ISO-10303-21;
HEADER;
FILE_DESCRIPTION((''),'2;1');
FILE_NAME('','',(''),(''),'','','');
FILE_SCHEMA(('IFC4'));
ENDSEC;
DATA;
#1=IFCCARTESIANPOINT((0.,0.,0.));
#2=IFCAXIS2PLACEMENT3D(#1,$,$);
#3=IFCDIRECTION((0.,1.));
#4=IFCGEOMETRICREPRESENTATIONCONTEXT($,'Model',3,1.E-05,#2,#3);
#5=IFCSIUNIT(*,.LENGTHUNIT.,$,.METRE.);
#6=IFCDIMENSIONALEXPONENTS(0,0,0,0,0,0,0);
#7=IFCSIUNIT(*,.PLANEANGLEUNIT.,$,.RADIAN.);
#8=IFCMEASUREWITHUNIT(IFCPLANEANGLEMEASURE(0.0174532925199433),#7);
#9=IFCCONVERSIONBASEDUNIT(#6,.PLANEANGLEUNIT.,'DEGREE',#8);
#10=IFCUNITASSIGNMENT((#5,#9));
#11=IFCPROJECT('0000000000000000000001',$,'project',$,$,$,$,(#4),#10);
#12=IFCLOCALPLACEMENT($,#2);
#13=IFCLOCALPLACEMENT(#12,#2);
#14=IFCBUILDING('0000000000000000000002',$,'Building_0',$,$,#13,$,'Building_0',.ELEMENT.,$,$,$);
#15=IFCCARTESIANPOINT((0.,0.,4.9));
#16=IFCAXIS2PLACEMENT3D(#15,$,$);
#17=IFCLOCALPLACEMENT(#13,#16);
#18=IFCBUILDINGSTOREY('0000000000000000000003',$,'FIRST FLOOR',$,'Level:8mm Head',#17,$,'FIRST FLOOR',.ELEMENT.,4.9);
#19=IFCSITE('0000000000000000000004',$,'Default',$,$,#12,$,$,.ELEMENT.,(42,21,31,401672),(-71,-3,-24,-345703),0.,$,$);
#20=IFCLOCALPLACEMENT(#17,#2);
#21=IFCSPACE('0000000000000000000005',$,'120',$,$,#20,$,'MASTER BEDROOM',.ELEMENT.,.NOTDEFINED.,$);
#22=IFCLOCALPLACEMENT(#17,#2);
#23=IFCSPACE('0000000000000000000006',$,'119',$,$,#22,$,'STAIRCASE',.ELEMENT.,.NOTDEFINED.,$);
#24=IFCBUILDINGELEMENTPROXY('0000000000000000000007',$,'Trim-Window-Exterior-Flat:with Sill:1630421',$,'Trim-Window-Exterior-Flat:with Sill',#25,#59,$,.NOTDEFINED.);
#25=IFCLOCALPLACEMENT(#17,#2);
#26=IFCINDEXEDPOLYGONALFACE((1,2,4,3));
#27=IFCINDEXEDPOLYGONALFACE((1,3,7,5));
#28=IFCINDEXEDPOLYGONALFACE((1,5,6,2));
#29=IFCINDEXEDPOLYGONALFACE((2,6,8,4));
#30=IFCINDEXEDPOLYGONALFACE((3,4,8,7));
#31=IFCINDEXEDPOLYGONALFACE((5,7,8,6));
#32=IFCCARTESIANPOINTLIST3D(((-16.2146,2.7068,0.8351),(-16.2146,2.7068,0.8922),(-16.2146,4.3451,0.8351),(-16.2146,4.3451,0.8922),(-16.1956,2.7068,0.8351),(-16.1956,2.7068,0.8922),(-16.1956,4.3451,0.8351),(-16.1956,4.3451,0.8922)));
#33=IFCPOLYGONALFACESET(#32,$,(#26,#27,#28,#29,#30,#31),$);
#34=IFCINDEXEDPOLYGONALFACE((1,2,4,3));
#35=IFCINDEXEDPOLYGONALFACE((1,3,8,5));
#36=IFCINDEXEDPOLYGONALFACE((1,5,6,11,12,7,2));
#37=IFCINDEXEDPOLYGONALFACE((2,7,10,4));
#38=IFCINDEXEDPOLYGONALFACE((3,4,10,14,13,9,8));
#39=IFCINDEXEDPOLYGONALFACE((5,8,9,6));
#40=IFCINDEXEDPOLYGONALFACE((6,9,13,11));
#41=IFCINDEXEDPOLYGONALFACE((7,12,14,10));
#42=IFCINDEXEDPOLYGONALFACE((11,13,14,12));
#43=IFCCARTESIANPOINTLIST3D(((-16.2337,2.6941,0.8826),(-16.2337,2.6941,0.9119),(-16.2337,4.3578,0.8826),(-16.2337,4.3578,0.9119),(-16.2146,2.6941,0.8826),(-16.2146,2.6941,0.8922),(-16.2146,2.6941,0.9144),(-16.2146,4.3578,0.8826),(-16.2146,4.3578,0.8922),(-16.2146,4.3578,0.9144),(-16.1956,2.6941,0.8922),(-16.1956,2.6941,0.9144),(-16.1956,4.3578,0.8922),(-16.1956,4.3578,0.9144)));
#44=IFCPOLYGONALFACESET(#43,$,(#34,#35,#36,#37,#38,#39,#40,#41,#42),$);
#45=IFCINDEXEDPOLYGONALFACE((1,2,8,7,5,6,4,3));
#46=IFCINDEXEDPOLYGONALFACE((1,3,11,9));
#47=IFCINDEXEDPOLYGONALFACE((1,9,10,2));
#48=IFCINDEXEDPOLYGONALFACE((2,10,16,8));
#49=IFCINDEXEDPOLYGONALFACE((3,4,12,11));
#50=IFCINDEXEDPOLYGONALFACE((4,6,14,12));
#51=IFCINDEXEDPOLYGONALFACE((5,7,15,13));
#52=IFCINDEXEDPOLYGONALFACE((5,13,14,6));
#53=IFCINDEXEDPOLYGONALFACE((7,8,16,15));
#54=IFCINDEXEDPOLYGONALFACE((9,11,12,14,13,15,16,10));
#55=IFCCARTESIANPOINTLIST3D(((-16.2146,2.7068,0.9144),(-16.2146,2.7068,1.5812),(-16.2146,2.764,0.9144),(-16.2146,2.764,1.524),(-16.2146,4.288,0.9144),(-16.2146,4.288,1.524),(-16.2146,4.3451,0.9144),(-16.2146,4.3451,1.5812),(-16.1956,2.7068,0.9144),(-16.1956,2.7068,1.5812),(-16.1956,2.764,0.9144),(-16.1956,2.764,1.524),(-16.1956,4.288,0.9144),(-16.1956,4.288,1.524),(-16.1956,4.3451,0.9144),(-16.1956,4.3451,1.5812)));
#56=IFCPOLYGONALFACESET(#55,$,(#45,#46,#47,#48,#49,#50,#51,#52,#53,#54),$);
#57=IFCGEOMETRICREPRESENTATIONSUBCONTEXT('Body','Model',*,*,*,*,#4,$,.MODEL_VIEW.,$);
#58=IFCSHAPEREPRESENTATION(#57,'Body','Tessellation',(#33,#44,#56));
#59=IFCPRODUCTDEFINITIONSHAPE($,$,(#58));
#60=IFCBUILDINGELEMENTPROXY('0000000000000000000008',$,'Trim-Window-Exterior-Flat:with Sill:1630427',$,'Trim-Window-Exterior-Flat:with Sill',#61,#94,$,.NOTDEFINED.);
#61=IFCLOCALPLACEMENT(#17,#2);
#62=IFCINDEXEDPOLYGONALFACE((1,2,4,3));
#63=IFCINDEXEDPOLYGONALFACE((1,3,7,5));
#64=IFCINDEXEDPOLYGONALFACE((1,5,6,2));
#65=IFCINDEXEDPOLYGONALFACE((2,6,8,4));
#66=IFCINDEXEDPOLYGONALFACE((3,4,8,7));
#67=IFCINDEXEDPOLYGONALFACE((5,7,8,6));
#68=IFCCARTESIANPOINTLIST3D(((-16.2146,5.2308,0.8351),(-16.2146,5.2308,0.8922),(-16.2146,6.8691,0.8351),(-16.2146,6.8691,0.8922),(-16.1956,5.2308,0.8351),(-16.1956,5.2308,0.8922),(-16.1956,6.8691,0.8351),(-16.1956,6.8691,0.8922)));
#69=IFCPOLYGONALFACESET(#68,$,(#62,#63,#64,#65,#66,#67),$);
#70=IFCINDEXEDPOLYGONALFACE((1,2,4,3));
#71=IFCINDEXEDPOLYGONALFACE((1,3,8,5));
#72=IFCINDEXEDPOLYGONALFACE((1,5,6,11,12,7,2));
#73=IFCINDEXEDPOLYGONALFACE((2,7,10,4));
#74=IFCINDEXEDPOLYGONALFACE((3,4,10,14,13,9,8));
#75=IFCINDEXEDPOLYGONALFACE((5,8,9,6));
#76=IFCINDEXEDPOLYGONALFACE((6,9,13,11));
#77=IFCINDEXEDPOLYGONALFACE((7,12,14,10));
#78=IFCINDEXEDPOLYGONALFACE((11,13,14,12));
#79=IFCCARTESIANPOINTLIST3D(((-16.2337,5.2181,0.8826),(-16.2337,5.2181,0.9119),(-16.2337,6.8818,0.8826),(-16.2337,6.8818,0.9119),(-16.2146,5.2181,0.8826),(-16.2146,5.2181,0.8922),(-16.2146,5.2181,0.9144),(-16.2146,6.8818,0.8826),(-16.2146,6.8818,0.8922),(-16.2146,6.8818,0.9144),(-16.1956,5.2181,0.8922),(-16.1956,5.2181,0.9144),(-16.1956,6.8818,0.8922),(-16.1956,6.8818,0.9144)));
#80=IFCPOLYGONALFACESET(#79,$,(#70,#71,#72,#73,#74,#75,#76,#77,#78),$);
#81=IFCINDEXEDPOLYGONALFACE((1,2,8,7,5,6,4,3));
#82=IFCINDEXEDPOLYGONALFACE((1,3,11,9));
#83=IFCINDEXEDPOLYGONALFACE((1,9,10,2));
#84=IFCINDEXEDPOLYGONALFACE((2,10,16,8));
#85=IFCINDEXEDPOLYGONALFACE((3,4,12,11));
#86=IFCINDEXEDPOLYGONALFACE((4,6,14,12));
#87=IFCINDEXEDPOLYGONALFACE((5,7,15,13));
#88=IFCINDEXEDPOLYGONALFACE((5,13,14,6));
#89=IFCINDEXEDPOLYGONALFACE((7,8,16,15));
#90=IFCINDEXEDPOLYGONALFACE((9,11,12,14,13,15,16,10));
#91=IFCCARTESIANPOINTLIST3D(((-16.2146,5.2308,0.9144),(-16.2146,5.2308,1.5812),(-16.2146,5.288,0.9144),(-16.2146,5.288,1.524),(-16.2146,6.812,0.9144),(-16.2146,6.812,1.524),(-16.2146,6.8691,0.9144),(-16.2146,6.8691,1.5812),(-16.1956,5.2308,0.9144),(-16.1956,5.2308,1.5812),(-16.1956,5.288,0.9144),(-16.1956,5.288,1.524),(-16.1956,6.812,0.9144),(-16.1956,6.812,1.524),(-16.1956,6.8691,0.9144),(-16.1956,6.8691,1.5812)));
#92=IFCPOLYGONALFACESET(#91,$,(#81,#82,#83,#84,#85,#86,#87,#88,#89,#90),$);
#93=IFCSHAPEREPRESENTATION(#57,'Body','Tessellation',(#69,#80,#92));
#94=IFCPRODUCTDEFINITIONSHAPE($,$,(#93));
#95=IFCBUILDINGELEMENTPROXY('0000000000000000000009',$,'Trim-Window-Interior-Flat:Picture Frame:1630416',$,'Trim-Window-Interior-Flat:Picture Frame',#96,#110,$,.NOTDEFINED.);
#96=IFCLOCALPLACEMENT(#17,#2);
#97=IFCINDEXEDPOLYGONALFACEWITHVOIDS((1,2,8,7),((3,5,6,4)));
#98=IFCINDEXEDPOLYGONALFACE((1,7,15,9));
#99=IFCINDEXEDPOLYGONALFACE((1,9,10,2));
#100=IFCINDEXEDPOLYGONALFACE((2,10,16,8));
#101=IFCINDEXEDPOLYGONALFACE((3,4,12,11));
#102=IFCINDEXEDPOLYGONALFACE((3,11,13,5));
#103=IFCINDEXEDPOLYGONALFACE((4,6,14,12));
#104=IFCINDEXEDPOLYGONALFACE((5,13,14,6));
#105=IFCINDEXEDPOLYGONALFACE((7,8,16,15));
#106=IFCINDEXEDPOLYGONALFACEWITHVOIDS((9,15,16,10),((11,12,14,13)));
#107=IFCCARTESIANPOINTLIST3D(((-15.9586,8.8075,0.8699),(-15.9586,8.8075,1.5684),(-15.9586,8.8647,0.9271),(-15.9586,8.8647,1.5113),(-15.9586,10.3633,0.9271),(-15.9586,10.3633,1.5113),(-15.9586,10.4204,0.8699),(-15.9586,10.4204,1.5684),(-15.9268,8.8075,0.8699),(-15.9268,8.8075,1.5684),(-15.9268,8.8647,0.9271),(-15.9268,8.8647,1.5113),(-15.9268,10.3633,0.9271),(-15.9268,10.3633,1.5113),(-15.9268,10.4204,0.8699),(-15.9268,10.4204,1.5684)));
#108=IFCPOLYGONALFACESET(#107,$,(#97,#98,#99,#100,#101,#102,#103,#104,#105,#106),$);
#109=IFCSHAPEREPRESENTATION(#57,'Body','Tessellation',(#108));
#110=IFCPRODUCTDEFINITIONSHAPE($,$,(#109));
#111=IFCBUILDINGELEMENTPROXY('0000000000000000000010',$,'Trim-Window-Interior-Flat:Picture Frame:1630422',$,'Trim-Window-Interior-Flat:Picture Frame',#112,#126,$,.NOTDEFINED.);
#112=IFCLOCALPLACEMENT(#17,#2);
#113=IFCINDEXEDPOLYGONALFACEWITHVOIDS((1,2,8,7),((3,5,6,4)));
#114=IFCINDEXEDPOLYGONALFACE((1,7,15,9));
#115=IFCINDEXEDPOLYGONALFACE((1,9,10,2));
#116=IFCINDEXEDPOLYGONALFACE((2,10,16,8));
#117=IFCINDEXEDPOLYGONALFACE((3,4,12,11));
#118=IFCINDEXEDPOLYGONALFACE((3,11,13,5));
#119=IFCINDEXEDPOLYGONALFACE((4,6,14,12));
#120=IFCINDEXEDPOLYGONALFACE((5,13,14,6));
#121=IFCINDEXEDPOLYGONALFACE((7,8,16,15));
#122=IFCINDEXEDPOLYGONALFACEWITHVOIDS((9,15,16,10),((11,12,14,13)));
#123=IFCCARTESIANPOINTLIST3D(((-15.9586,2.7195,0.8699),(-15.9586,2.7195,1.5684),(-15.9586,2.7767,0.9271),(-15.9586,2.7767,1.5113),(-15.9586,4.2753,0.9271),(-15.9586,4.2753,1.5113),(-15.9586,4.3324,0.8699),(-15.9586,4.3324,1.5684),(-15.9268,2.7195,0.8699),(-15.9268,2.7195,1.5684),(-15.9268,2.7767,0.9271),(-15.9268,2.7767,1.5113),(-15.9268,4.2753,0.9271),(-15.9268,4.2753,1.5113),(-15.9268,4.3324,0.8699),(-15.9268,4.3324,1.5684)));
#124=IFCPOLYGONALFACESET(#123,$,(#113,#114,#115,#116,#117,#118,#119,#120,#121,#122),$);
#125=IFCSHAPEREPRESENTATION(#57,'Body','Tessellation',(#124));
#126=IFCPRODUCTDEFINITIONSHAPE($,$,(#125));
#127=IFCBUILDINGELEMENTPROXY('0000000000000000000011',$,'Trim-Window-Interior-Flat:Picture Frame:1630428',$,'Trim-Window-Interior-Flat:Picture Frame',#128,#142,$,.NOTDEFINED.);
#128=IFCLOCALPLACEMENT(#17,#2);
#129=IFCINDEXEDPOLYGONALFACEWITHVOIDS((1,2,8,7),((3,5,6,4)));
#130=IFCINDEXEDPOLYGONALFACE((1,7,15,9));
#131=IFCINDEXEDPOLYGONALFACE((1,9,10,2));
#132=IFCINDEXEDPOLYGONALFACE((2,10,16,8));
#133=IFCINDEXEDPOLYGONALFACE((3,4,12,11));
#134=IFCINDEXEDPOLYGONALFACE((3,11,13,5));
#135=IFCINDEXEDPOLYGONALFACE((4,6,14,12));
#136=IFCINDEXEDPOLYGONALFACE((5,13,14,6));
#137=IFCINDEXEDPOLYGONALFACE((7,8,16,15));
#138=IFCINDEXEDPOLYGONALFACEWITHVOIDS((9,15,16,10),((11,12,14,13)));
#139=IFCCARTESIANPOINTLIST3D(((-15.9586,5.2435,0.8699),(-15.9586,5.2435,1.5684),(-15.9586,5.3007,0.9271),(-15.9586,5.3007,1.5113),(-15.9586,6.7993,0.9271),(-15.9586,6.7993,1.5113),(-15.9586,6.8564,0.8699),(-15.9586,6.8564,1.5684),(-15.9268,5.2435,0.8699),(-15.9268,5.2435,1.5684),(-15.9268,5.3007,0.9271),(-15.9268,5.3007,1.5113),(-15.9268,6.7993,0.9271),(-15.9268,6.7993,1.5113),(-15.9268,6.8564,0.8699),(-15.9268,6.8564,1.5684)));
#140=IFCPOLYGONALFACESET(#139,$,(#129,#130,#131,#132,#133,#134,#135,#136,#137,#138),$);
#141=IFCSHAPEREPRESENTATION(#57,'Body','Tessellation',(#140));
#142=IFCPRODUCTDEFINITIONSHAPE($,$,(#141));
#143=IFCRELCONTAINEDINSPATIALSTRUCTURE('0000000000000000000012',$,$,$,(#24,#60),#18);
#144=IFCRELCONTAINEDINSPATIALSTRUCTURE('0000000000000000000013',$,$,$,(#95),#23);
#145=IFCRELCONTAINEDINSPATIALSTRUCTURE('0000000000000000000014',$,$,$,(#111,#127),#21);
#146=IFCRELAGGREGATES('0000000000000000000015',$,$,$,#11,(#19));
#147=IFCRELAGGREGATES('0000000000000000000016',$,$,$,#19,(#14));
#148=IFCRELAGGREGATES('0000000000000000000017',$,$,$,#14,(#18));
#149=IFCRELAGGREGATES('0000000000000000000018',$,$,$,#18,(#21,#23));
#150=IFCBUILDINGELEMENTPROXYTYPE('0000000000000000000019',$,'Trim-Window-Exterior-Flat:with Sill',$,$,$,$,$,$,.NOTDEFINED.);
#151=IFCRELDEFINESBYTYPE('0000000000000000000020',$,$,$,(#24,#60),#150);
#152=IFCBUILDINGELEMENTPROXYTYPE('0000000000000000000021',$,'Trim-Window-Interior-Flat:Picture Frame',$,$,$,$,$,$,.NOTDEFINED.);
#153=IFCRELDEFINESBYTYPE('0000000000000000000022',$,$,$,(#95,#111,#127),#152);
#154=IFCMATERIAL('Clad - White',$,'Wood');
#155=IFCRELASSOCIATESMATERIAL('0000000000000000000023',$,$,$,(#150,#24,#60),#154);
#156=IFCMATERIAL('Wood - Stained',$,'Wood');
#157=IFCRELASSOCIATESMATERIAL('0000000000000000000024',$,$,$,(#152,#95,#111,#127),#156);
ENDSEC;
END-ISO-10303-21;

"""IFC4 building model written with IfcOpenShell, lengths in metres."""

from ifc_helpers import new_model, entity, si_unit, converted_unit, direction, frame, origin, place, context, subcontext, project, spatial, indexed_curve, outline, extrude, source, transform, mapped, material, type_object, type_shapes, element, save


model = new_model("IFC4")

# Units and contexts
model_context = context("Model", 3, precision=1e-05, world=origin(), true_north=direction((0.0, 1.0)))
body_context = subcontext(model_context, "Body", "Model", "MODEL_VIEW")
ifc_project = project(units=[si_unit("LENGTHUNIT", "METRE"), converted_unit("PLANEANGLEUNIT", "DEGREE", entity("IfcPlaneAngleMeasure", 0.0174532925199433), si_unit("PLANEANGLEUNIT", "RADIAN"), dimensions=[0, 0, 0, 0, 0, 0, 0])], contexts=[model_context])

# Site, building, storey
site_placement = place(None, origin())
site = spatial("IfcSite", under=ifc_project, at=site_placement, Name="Default", CompositionType="ELEMENT", RefLatitude=(42, 21, 31, 401672), RefLongitude=(-71, -3, -24, -345703), RefElevation=0.0)
building_placement = place(site_placement, origin())
building = spatial("IfcBuilding", under=site, at=building_placement, Name="Building_0", LongName="Building_0", CompositionType="ELEMENT")
storey_placement = place(building_placement, frame((0.0, 0.0, 4.9)))
storey = spatial("IfcBuildingStorey", under=building, at=storey_placement, Name="FIRST FLOOR", ObjectType="Level:8mm Head", LongName="FIRST FLOOR", CompositionType="ELEMENT", Elevation=4.9)

# Shared definitions
ifc_material_1 = material(Name="Clad - White", Category="Wood")

# Shared definitions
space_1_placement = place(storey_placement, origin())
space_1 = spatial("IfcSpace", under=storey, at=space_1_placement, Name="120", LongName="MASTER BEDROOM", CompositionType="ELEMENT", PredefinedType="NOTDEFINED")

# Building element proxies
ifc_material_2 = material(Name="Wood - Stained", Category="Wood")
building_element_proxy_type_1 = type_object("IfcBuildingElementProxyType", Name="Trim-Window-Exterior-Flat:with Sill", PredefinedType="NOTDEFINED", material=ifc_material_1)
shared_shape_1 = source(origin(), body_context, "Body", "SweptSolid", [
    extrude(outline(indexed_curve([(-0.8191, -0.0286), (0.8191, -0.0286), (0.8191, 0.0286), (-0.8191, 0.0286), (-0.8191, -0.0286)], self_intersect=False)), frame((0.0, -0.6604, 0.0), z_axis=(0.0, 0.0, 1.0), x_axis=(-1.0, 0.0, 0.0)), (0.0, 0.0, 1.0), 0.0191),
    extrude(outline(indexed_curve([(-0.019, -0.016), (0.0, -0.016), (0.0, -0.0064), (0.019, -0.0064), (0.019, 0.0158), (0.0, 0.0158), (-0.019, 0.0133), (-0.019, -0.016)], self_intersect=False)), frame((-0.8318, -0.6254, 0.019), z_axis=(1.0, 0.0, 0.0), x_axis=(0.0, 0.0, -1.0)), (0.0, 0.0, 1.0), 1.6637),
    extrude(outline(indexed_curve([(-0.3477, -0.8192), (0.3191, -0.8192), (0.3191, -0.762), (-0.2905, -0.762), (-0.2905, 0.762), (0.3191, 0.762), (0.3191, 0.8191), (-0.3477, 0.8191), (-0.3477, -0.8192)], self_intersect=False)), frame((0.0, -0.2905, 0.0), z_axis=(0.0, 0.0, 1.0), x_axis=(0.0, -1.0, 0.0)), (0.0, 0.0, 1.0), 0.0191),
])
type_shapes(building_element_proxy_type_1, [shared_shape_1])
for number, where, z_axis, x_axis, name in (
    (1, (-16.1956, 3.526, 1.524), (-1.0, 0.0, 0.0), (0.0, -1.0, 0.0), "Trim-Window-Exterior-Flat:with Sill:1630421"),
    (2, (-16.1956, 6.05, 1.524), (-1.0, 0.0, 0.0), (0.0, -1.0, 0.0), "Trim-Window-Exterior-Flat:with Sill:1630427"),
):
    element("IfcBuildingElementProxy", number, at=place(storey_placement, frame(where, z_axis=z_axis, x_axis=x_axis)), inside=storey, type_object=building_element_proxy_type_1, material=ifc_material_1, Name=name, ObjectType="Trim-Window-Exterior-Flat:with Sill", PredefinedType="NOTDEFINED", context=body_context, shape_type="MappedRepresentation", body=[
        mapped(shared_shape_1, transform((0.0, 0.0, 0.0), scale=1.0)),
    ])

# Shared definitions
space_2_placement = place(storey_placement, origin())
space_2 = spatial("IfcSpace", under=storey, at=space_2_placement, Name="119", LongName="STAIRCASE", CompositionType="ELEMENT", PredefinedType="NOTDEFINED")

# Building element proxies
building_element_proxy_type_2 = type_object("IfcBuildingElementProxyType", Name="Trim-Window-Interior-Flat:Picture Frame", PredefinedType="NOTDEFINED", material=ifc_material_2)
shared_shape_2 = source(origin(), body_context, "Body", "SweptSolid", [
    extrude(outline(indexed_curve([(-0.8064, -0.3492), (0.8064, -0.3492), (0.8064, 0.3492), (-0.8064, 0.3492), (-0.8064, -0.3492)], self_intersect=False), holes=[indexed_curve([(-0.7493, -0.2921), (-0.7493, 0.2921), (0.7493, 0.2921), (0.7493, -0.2921), (-0.7493, -0.2921)], self_intersect=False)]), frame((0.0, -0.3048, 0.0), z_axis=(0.0, 0.0, 1.0), x_axis=(-1.0, 0.0, 0.0)), (0.0, 0.0, 1.0), 0.0318),
])
type_shapes(building_element_proxy_type_2, [shared_shape_2])
proxy_1_placement = place(space_2_placement, frame((-15.9586, 9.614, 1.524), z_axis=(1.0, 0.0, 0.0), x_axis=(0.0, 1.0, 0.0)))
element("IfcBuildingElementProxy", 3, at=proxy_1_placement, inside=space_2, type_object=building_element_proxy_type_2, material=ifc_material_2, Name="Trim-Window-Interior-Flat:Picture Frame:1630416", ObjectType="Trim-Window-Interior-Flat:Picture Frame", PredefinedType="NOTDEFINED", context=body_context, shape_type="MappedRepresentation", body=[
    mapped(shared_shape_2, transform((0.0, 0.0, 0.0), scale=1.0)),
])
for number, where, z_axis, x_axis, name in (
    (4, (-15.9586, 3.526, 1.524), (1.0, 0.0, 0.0), (0.0, 1.0, 0.0), "Trim-Window-Interior-Flat:Picture Frame:1630422"),
    (5, (-15.9586, 6.05, 1.524), (1.0, 0.0, 0.0), (0.0, 1.0, 0.0), "Trim-Window-Interior-Flat:Picture Frame:1630428"),
):
    element("IfcBuildingElementProxy", number, at=place(space_1_placement, frame(where, z_axis=z_axis, x_axis=x_axis)), inside=space_1, type_object=building_element_proxy_type_2, material=ifc_material_2, Name=name, ObjectType="Trim-Window-Interior-Flat:Picture Frame", PredefinedType="NOTDEFINED", context=body_context, shape_type="MappedRepresentation", body=[
        mapped(shared_shape_2, transform((0.0, 0.0, 0.0), scale=1.0)),
    ])

save(model, "model.ifc")
